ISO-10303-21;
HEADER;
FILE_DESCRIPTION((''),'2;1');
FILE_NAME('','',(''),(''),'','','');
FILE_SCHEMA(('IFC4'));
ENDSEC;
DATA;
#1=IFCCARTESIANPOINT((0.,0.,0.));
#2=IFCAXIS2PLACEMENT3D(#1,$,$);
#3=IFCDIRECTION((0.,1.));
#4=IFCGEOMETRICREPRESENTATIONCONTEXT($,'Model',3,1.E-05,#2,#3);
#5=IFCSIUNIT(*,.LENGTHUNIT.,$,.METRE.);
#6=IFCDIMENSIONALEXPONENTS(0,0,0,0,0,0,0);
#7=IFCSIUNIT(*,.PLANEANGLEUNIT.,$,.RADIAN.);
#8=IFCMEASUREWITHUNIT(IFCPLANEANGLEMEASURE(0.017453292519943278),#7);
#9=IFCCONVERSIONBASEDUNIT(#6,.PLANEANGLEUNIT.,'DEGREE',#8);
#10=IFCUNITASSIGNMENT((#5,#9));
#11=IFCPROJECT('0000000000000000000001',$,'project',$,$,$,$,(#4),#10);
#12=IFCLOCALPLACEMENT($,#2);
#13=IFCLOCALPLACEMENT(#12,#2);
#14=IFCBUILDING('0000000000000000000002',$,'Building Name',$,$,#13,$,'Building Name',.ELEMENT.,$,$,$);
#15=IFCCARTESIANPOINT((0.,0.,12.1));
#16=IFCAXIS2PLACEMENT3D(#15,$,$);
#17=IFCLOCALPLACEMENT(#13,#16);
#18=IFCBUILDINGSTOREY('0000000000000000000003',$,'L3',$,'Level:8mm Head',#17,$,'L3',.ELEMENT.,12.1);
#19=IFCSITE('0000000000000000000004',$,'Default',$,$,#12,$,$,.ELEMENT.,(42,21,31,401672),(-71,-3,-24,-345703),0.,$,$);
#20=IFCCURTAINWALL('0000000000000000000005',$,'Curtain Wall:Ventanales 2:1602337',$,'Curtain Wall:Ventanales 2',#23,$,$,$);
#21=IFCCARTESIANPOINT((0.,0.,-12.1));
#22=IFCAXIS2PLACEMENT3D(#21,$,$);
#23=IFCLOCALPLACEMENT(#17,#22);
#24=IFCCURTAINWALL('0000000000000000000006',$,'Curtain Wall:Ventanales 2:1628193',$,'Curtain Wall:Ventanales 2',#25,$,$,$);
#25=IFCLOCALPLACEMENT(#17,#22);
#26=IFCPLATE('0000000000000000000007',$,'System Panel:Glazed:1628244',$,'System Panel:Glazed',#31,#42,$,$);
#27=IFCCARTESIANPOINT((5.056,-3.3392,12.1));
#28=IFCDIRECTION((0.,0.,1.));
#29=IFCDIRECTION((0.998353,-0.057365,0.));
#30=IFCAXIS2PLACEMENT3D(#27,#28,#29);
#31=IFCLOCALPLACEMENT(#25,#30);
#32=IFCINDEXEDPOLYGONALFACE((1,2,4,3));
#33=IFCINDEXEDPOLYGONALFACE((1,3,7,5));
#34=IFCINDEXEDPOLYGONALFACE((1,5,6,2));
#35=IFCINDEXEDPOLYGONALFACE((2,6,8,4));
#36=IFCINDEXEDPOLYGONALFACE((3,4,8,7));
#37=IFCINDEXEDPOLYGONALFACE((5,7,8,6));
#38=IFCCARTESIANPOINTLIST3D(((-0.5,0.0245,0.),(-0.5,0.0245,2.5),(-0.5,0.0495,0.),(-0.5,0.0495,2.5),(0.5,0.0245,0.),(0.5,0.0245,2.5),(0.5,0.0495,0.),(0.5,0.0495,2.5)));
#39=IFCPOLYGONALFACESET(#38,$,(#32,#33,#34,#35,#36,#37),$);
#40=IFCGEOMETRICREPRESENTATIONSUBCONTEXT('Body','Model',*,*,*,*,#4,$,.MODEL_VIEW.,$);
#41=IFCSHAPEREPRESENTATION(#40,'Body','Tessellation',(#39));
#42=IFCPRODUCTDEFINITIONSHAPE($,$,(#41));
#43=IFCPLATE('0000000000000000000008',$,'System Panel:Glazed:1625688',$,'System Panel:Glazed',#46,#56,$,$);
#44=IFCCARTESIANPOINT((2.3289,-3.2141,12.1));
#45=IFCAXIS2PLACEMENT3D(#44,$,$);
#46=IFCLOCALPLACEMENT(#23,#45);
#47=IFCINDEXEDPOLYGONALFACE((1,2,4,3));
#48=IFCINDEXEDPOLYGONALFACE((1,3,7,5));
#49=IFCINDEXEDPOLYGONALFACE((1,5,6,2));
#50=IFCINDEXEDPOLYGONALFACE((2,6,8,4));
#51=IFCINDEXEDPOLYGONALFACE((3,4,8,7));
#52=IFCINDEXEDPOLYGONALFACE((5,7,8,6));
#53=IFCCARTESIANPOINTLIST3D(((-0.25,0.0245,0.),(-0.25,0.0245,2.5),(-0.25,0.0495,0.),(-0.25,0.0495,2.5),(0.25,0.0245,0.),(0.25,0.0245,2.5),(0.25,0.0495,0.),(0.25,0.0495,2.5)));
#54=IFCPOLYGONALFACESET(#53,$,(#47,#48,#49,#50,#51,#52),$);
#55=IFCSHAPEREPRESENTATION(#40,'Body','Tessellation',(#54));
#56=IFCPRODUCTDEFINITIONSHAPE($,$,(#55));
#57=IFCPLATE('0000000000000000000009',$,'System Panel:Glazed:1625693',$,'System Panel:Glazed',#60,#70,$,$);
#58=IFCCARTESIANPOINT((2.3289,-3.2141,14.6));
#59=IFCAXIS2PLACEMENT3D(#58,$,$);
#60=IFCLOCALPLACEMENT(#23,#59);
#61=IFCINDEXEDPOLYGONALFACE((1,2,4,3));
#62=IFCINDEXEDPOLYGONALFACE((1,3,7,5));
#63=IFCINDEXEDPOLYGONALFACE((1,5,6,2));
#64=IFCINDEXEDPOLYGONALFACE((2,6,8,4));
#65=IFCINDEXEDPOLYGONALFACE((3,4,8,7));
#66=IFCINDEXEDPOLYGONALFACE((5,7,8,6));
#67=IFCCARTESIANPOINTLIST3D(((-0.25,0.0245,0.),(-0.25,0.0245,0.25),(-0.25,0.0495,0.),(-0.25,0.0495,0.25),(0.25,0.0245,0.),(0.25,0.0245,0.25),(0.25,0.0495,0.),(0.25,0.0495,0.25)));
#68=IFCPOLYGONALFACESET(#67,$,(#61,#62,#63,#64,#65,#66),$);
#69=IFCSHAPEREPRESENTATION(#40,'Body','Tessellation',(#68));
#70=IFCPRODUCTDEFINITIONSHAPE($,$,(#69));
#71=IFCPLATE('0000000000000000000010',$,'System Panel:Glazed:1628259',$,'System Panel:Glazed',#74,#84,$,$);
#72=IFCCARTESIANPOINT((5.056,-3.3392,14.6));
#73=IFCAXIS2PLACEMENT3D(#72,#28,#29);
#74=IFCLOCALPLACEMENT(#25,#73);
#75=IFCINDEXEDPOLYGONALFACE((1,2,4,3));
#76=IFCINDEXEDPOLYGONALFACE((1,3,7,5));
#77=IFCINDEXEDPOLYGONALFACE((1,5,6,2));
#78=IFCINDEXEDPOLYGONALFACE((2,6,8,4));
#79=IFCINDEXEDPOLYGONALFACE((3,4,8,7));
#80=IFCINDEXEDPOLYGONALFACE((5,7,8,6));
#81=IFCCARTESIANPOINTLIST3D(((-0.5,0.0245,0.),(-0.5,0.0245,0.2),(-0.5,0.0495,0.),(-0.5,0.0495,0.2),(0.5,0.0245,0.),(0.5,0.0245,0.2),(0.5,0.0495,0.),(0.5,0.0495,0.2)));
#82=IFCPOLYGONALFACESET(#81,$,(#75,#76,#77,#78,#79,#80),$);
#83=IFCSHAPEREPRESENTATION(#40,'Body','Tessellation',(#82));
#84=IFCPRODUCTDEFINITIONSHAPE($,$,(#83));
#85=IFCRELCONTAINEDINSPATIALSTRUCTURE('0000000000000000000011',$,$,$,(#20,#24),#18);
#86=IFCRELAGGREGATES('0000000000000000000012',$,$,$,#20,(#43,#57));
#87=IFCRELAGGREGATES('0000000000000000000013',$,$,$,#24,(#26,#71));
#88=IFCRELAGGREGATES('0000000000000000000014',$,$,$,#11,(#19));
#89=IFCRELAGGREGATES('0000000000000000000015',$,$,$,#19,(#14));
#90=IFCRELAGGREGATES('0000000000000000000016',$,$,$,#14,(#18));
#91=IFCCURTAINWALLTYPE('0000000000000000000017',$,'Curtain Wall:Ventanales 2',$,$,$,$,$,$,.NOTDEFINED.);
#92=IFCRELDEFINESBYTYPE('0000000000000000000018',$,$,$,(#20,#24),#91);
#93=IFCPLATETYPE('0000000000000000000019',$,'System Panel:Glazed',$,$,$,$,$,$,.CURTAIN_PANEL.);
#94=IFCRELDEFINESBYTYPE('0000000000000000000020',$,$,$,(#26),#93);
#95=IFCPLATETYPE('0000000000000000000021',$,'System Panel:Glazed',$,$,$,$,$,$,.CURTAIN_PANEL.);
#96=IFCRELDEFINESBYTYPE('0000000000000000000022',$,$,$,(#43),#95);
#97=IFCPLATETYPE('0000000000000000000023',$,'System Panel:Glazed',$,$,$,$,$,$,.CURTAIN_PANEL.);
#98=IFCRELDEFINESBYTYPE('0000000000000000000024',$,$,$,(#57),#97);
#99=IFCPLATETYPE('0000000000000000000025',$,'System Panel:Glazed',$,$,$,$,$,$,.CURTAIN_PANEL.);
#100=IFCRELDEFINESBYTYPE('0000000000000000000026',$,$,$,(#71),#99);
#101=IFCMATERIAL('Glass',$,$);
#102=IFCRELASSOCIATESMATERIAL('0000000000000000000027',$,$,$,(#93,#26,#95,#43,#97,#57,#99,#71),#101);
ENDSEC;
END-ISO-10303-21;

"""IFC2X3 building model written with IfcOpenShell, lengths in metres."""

from ifc_helpers import new_model, entity, si_unit, converted_unit, direction, frame, origin, origin_2d_with_axis, place, context, subcontext, project, spatial, rectangle, extrude, source, transform, mapped, material, type_object, type_shapes, element, aggregate, save


model = new_model("IFC2X3")

# Units and contexts
model_context = context("Model", 3, precision=1e-05, world=origin(), true_north=direction((0.0, 1.0)))
body_context = subcontext(model_context, "Body", "Model", "MODEL_VIEW")
ifc_project = project(units=[si_unit("LENGTHUNIT", "METRE"), converted_unit("PLANEANGLEUNIT", "DEGREE", entity("IfcPlaneAngleMeasure", 0.017453292519943278), si_unit("PLANEANGLEUNIT", "RADIAN"), dimensions=[0, 0, 0, 0, 0, 0, 0])], contexts=[model_context])

# Site, building, storey
site_placement = place(None, origin())
site = spatial("IfcSite", under=ifc_project, at=site_placement, Name="Default", CompositionType="ELEMENT", RefLatitude=(42, 21, 31, 401672), RefLongitude=(-71, -3, -24, -345703), RefElevation=0.0)
building_placement = place(site_placement, origin())
building = spatial("IfcBuilding", under=site, at=building_placement, Name="Building Name", LongName="Building Name", CompositionType="ELEMENT")
storey_placement = place(building_placement, frame((0.0, 0.0, 12.1)))
storey = spatial("IfcBuildingStorey", under=building, at=storey_placement, Name="L3", ObjectType="Level:8mm Head", LongName="L3", CompositionType="ELEMENT", Elevation=12.1)

# Curtain wall
curtain_wall_type = type_object("IfcCurtainWallType", Name="Curtain Wall:Ventanales 2", PredefinedType="NOTDEFINED")
curtain_wall_1_placement = place(storey_placement, frame((0.0, 0.0, -12.1)))
curtain_wall_1 = element("IfcCurtainWall", 1, at=curtain_wall_1_placement, inside=storey, type_object=curtain_wall_type, Name="Curtain Wall:Ventanales 2:1602337", ObjectType="Curtain Wall:Ventanales 2")

# Curtain wall
curtain_wall_2_placement = place(storey_placement, frame((0.0, 0.0, -12.1)))
curtain_wall_2 = element("IfcCurtainWall", 2, at=curtain_wall_2_placement, inside=storey, type_object=curtain_wall_type, Name="Curtain Wall:Ventanales 2:1628193", ObjectType="Curtain Wall:Ventanales 2")

# Plates
ifc_material_1 = material(Name="Glass")
plate_type_1 = type_object("IfcPlateType", Name="System Panel:Glazed", PredefinedType="CURTAIN_PANEL", material=ifc_material_1)
shared_shape_1 = source(origin(), body_context, "Body", "SweptSolid", [
    extrude(rectangle(XDim=0.025, YDim=1.0, at=origin_2d_with_axis()), frame((0.0, 0.037, 0.0), z_axis=(0.0, 0.0, 1.0), x_axis=(0.0, 1.0, 0.0)), (0.0, 0.0, 1.0), 2.5),
])
type_shapes(plate_type_1, [shared_shape_1])
plate_1_placement = place(curtain_wall_2_placement, frame((5.056, -3.3392, 12.1), z_axis=(0.0, 0.0, 1.0), x_axis=(0.998353, -0.057365, 0.0)))
plate_1 = element("IfcPlate", 3, at=plate_1_placement, type_object=plate_type_1, material=ifc_material_1, Name="System Panel:Glazed:1628244", ObjectType="System Panel:Glazed", context=body_context, shape_type="MappedRepresentation", body=[
    mapped(shared_shape_1, transform((0.0, 0.0, 0.0), scale=1.0)),
])
plate_type_2 = type_object("IfcPlateType", Name="System Panel:Glazed", PredefinedType="CURTAIN_PANEL", material=ifc_material_1)
shared_shape_2 = source(origin(), body_context, "Body", "SweptSolid", [
    extrude(rectangle(XDim=0.025, YDim=0.5, at=origin_2d_with_axis()), frame((0.0, 0.037, 0.0), z_axis=(0.0, 0.0, 1.0), x_axis=(0.0, 1.0, 0.0)), (0.0, 0.0, 1.0), 2.5),
])
type_shapes(plate_type_2, [shared_shape_2])
plate_2_placement = place(curtain_wall_1_placement, frame((2.3289, -3.2141, 12.1)))
plate_2 = element("IfcPlate", 4, at=plate_2_placement, type_object=plate_type_2, material=ifc_material_1, Name="System Panel:Glazed:1625688", ObjectType="System Panel:Glazed", context=body_context, shape_type="MappedRepresentation", body=[
    mapped(shared_shape_2, transform((0.0, 0.0, 0.0), scale=1.0)),
])
plate_type_3 = type_object("IfcPlateType", Name="System Panel:Glazed", PredefinedType="CURTAIN_PANEL", material=ifc_material_1)
shared_shape_3 = source(origin(), body_context, "Body", "SweptSolid", [
    extrude(rectangle(XDim=0.025, YDim=0.5, at=origin_2d_with_axis()), frame((0.0, 0.037, 0.0), z_axis=(0.0, 0.0, 1.0), x_axis=(0.0, 1.0, 0.0)), (0.0, 0.0, 1.0), 0.25),
])
type_shapes(plate_type_3, [shared_shape_3])
plate_3_placement = place(curtain_wall_1_placement, frame((2.3289, -3.2141, 14.6)))
plate_3 = element("IfcPlate", 5, at=plate_3_placement, type_object=plate_type_3, material=ifc_material_1, Name="System Panel:Glazed:1625693", ObjectType="System Panel:Glazed", context=body_context, shape_type="MappedRepresentation", body=[
    mapped(shared_shape_3, transform((0.0, 0.0, 0.0), scale=1.0)),
])
aggregate(curtain_wall_1, [plate_2, plate_3])
plate_type_4 = type_object("IfcPlateType", Name="System Panel:Glazed", PredefinedType="CURTAIN_PANEL", material=ifc_material_1)
shared_shape_4 = source(origin(), body_context, "Body", "SweptSolid", [
    extrude(rectangle(XDim=0.025, YDim=1.0, at=origin_2d_with_axis()), frame((0.0, 0.037, 0.0), z_axis=(0.0, 0.0, 1.0), x_axis=(0.0, 1.0, 0.0)), (0.0, 0.0, 1.0), 0.2),
])
type_shapes(plate_type_4, [shared_shape_4])
plate_4_placement = place(curtain_wall_2_placement, frame((5.056, -3.3392, 14.6), z_axis=(0.0, 0.0, 1.0), x_axis=(0.998353, -0.057365, 0.0)))
plate_4 = element("IfcPlate", 6, at=plate_4_placement, type_object=plate_type_4, material=ifc_material_1, Name="System Panel:Glazed:1628259", ObjectType="System Panel:Glazed", context=body_context, shape_type="MappedRepresentation", body=[
    mapped(shared_shape_4, transform((0.0, 0.0, 0.0), scale=1.0)),
])
aggregate(curtain_wall_2, [plate_1, plate_4])

save(model, "model.ifc")
